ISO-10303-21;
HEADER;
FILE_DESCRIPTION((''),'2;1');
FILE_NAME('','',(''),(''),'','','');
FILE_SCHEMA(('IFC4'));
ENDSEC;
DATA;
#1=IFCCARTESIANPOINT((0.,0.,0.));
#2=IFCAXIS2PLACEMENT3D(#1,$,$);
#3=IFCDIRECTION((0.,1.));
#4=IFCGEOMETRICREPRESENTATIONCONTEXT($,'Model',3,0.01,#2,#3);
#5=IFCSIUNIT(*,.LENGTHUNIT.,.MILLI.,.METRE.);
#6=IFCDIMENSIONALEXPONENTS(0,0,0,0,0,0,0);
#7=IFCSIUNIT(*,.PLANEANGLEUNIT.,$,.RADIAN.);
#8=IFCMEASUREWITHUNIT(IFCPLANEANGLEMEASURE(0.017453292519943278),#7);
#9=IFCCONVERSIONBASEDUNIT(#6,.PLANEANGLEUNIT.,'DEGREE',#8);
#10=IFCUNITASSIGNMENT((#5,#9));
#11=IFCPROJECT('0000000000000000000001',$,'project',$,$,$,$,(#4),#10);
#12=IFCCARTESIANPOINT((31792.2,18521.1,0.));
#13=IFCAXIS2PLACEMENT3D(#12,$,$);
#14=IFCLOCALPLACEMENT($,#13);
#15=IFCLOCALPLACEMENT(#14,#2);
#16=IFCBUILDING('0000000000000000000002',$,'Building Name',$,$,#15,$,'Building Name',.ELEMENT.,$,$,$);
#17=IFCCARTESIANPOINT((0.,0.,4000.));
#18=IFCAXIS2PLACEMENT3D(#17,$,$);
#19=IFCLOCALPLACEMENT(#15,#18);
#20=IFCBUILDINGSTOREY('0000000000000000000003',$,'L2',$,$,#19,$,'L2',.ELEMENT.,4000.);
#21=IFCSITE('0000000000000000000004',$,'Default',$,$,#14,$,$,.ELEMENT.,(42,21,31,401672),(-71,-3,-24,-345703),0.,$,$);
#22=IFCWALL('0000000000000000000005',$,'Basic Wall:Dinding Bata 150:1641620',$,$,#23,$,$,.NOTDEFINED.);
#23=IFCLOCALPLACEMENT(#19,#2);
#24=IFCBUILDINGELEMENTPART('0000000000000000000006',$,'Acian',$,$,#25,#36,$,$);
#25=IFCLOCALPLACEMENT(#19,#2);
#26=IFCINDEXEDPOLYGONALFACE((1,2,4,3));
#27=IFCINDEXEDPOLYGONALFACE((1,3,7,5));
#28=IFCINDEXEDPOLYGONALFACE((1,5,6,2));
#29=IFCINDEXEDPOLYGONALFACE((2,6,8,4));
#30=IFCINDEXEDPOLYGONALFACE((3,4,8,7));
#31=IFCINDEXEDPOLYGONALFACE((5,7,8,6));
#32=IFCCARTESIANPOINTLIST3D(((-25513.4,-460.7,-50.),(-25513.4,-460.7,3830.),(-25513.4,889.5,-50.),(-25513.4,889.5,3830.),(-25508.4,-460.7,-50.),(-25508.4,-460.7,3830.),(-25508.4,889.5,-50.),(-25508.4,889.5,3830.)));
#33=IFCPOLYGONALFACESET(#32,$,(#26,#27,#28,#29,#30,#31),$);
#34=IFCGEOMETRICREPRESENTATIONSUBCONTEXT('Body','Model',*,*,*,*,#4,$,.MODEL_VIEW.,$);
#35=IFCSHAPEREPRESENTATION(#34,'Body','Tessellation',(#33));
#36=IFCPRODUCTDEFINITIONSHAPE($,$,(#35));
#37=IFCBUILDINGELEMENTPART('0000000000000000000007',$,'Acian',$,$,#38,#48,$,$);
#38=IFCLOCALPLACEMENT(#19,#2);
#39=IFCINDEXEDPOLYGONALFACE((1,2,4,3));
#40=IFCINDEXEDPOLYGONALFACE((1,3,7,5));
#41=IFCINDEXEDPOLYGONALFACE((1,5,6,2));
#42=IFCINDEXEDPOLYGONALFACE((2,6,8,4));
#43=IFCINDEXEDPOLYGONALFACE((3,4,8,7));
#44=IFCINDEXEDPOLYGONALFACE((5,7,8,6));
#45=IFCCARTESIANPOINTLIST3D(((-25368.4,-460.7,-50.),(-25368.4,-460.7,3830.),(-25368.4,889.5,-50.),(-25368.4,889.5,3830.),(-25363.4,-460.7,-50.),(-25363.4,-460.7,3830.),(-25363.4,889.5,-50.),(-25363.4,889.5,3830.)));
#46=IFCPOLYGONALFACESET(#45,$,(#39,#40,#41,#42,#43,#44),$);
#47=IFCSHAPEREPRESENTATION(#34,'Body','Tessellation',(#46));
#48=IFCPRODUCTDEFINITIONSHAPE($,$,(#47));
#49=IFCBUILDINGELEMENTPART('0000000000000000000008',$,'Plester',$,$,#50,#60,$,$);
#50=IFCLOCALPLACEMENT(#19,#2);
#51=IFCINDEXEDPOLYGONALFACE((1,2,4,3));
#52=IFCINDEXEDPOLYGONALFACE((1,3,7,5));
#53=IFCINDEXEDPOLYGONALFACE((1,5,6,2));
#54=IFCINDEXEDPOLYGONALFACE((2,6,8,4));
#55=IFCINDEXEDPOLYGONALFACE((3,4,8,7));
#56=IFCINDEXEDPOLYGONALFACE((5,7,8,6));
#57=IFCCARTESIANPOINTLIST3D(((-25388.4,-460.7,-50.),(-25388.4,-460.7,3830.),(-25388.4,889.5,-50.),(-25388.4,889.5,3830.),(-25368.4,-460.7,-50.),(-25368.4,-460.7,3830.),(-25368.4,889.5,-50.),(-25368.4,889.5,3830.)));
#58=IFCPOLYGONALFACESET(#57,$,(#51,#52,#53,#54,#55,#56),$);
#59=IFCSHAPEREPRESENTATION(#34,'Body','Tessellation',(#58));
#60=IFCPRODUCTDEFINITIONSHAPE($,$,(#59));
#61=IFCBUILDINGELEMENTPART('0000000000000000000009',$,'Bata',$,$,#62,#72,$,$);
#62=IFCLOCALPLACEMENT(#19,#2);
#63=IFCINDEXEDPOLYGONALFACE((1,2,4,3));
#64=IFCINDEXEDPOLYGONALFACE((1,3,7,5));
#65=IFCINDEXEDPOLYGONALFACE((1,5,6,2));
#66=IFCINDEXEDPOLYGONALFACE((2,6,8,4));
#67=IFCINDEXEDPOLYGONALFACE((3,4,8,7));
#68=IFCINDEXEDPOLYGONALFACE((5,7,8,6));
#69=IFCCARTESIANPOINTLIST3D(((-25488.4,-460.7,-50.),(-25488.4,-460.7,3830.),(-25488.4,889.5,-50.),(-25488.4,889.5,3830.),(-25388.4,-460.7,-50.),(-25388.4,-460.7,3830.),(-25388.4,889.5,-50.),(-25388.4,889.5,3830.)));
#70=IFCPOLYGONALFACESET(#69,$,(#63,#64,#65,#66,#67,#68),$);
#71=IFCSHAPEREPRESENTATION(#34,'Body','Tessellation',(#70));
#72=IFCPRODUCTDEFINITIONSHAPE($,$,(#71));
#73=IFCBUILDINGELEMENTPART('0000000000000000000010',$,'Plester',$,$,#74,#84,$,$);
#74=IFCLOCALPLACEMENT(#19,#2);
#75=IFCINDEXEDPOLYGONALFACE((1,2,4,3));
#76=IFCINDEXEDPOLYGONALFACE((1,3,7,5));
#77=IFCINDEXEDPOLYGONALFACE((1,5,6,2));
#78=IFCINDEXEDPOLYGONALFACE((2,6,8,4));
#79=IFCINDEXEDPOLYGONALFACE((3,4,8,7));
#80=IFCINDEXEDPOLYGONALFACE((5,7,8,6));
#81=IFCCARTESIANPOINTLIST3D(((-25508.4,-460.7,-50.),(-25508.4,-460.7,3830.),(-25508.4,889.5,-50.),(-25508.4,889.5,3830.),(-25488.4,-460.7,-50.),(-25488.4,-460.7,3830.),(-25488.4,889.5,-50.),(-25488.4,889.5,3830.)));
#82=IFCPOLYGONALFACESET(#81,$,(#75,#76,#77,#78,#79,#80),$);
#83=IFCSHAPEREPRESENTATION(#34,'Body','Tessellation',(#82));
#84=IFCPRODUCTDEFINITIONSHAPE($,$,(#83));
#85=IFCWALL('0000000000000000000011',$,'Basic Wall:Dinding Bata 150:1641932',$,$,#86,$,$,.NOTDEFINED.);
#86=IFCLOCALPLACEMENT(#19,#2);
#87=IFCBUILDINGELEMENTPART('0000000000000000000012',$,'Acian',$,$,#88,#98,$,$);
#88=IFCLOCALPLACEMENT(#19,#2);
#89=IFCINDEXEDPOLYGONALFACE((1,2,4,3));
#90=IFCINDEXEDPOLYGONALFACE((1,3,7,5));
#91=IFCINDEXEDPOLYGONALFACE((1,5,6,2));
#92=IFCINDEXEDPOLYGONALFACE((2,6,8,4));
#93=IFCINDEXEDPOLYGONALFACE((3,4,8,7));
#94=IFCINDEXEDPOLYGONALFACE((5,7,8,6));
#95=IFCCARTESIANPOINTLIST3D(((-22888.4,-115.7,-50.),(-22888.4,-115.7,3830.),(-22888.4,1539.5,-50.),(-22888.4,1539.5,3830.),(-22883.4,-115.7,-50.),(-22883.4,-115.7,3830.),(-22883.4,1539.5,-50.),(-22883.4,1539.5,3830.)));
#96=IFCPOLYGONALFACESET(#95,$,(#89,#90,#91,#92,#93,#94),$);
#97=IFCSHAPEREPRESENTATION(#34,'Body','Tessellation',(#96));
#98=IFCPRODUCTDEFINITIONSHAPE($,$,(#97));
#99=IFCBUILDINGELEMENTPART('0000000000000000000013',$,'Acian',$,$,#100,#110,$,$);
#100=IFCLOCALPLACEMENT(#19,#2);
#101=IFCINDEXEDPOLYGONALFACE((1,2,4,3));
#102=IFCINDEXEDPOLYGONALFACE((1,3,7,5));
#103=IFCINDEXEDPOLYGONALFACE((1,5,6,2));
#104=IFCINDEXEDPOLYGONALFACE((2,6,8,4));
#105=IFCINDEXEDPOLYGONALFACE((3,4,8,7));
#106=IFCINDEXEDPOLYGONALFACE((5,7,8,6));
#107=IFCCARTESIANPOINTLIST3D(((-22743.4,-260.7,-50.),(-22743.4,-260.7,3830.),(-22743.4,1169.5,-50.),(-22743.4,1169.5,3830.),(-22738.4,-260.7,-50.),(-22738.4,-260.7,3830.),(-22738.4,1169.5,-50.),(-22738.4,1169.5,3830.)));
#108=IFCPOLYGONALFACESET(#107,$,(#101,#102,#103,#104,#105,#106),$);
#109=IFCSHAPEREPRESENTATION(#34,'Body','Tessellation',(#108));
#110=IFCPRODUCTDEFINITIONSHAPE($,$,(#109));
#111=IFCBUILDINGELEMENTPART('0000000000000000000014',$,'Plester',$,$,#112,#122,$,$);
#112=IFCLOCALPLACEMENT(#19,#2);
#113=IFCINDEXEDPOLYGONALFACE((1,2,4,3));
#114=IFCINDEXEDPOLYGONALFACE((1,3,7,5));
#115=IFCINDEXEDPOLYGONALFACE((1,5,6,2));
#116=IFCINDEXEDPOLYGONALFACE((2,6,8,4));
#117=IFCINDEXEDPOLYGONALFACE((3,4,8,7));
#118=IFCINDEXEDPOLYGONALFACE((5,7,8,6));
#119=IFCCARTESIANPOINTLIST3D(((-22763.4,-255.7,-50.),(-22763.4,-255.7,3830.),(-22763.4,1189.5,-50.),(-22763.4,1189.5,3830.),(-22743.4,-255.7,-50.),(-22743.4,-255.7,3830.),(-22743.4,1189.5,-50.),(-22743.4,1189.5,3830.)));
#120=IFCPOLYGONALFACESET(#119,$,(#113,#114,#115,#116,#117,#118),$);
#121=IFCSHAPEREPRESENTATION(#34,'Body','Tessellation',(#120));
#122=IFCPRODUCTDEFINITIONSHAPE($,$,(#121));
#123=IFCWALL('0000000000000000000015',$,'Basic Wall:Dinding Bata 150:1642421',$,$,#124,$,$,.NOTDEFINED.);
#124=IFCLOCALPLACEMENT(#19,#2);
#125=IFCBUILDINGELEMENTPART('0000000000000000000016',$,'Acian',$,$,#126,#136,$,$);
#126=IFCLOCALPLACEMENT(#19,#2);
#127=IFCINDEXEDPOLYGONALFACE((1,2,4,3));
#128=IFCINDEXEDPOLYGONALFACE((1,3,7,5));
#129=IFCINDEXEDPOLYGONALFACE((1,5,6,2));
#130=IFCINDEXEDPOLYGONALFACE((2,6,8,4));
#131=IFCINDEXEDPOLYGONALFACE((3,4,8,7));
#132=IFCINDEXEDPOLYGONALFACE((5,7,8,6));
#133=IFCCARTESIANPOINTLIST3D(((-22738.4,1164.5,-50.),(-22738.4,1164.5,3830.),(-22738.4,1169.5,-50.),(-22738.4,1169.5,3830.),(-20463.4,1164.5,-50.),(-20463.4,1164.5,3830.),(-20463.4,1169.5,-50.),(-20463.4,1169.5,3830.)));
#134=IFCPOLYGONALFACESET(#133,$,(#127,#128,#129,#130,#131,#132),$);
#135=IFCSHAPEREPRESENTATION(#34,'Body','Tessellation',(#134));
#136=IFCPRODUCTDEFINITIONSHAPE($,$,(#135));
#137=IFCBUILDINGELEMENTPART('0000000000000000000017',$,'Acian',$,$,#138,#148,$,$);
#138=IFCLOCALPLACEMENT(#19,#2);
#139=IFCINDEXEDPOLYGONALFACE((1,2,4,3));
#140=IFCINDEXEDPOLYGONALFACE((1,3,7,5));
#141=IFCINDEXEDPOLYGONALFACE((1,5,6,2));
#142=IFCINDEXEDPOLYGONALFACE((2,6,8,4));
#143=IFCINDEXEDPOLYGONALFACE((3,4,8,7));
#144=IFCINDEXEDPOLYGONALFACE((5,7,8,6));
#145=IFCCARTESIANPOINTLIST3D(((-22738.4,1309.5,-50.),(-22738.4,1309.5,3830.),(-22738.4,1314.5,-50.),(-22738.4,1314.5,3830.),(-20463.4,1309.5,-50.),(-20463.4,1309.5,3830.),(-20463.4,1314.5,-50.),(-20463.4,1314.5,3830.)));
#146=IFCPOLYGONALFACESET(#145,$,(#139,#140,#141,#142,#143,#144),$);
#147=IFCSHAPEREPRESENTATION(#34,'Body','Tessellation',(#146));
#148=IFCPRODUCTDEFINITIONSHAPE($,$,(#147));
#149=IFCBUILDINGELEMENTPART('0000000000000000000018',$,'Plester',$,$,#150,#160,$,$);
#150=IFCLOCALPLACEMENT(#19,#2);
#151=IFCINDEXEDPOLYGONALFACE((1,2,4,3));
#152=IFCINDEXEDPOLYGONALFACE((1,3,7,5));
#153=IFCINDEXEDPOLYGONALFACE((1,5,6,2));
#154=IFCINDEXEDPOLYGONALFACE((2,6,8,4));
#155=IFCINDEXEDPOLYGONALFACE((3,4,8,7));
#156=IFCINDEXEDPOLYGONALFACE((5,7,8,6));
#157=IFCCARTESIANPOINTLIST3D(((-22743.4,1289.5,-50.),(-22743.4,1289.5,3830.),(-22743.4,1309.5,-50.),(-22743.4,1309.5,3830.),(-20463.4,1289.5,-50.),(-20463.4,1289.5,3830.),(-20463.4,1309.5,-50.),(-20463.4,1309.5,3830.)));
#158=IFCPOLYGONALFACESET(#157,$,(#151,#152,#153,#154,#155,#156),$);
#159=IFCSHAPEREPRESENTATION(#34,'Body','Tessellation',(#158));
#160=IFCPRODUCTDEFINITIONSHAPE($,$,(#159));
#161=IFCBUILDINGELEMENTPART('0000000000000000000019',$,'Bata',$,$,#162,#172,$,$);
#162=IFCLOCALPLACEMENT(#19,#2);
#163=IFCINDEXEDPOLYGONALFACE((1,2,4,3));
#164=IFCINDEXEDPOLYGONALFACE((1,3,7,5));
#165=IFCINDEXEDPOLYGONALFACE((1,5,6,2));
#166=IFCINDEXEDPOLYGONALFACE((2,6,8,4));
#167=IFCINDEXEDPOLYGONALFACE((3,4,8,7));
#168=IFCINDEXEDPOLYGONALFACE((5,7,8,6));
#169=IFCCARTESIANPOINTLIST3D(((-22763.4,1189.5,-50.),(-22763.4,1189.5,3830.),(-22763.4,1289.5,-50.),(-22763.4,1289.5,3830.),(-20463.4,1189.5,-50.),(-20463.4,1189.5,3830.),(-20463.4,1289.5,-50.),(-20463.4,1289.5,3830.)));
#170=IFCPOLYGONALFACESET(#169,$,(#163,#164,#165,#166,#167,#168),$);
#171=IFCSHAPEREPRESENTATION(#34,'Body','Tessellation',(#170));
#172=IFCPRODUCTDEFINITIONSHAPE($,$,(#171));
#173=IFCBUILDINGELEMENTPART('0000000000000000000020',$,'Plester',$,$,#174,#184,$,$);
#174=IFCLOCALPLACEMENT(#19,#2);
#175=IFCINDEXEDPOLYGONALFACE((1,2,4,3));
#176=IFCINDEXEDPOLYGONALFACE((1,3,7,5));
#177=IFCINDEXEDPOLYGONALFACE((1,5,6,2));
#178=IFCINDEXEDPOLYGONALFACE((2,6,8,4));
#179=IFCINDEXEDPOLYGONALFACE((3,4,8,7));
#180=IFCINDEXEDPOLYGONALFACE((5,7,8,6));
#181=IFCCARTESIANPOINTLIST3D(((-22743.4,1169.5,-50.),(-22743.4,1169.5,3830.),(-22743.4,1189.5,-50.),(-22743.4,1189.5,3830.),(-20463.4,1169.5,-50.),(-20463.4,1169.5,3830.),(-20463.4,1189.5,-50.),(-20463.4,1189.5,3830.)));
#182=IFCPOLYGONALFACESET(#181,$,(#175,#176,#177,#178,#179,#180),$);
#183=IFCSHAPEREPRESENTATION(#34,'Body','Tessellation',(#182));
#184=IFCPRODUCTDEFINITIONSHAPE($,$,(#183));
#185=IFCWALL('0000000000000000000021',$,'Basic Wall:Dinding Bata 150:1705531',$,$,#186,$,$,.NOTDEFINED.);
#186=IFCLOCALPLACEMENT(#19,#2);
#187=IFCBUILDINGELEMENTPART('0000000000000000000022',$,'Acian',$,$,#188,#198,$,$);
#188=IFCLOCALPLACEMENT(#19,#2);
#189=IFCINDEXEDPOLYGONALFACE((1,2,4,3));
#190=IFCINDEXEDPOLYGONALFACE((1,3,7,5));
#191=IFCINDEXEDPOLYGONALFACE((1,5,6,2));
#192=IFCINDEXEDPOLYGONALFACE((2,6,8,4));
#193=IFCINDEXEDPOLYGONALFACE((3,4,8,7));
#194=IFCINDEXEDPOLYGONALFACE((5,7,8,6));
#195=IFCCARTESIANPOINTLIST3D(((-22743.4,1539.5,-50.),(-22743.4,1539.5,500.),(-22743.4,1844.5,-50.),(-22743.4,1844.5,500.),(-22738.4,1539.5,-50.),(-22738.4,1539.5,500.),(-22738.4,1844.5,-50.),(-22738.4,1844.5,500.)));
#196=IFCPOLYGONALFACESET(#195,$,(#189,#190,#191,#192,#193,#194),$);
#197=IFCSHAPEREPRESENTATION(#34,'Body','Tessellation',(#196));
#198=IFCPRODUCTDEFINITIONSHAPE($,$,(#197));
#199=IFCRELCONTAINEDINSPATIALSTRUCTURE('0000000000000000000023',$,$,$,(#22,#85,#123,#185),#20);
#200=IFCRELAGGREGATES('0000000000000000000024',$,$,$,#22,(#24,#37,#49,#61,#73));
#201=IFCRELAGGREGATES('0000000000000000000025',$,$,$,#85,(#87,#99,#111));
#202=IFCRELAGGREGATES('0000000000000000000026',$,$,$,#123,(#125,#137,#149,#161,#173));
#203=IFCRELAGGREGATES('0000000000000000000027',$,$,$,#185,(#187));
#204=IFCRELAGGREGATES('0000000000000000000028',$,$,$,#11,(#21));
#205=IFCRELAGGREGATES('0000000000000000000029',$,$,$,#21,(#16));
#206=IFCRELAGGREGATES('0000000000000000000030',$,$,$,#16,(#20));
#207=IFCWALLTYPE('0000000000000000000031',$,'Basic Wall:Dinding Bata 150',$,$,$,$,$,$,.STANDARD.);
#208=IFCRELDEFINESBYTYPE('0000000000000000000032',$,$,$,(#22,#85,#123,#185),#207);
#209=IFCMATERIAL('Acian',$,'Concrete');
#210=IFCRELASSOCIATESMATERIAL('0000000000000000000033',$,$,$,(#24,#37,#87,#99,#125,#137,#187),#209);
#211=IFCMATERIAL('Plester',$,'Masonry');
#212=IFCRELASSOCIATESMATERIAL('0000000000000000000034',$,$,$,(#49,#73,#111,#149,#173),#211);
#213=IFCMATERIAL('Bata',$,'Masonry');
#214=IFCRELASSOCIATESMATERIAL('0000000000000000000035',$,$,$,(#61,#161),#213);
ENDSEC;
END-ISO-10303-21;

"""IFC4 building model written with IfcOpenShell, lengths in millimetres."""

from ifc_helpers import new_model, entity, si_unit, converted_unit, direction, frame, origin, place, context, subcontext, project, spatial, indexed_curve, outline, extrude, material, type_object, element, aggregate, save


model = new_model("IFC4")

# Units and contexts
model_context = context("Model", 3, precision=0.01, world=origin(), true_north=direction((0.0, 1.0)))
body_context = subcontext(model_context, "Body", "Model", "MODEL_VIEW")
ifc_project = project(units=[si_unit("LENGTHUNIT", "METRE", prefix="MILLI"), converted_unit("PLANEANGLEUNIT", "DEGREE", entity("IfcPlaneAngleMeasure", 0.017453292519943278), si_unit("PLANEANGLEUNIT", "RADIAN"), dimensions=[0, 0, 0, 0, 0, 0, 0])], contexts=[model_context])

# Site, building, storey
site_placement = place(None, frame((31792.2, 18521.1, 0.0)))
site = spatial("IfcSite", under=ifc_project, at=site_placement, Name="Default", CompositionType="ELEMENT", RefLatitude=(42, 21, 31, 401672), RefLongitude=(-71, -3, -24, -345703), RefElevation=0.0)
building_placement = place(site_placement, origin())
building = spatial("IfcBuilding", under=site, at=building_placement, Name="Building Name", LongName="Building Name", CompositionType="ELEMENT")
storey_placement = place(building_placement, frame((0.0, 0.0, 4000.0)))
storey = spatial("IfcBuildingStorey", under=building, at=storey_placement, Name="L2", LongName="L2", CompositionType="ELEMENT", Elevation=4000.0)

# Walls, building element parts
wall_type_1 = type_object("IfcWallType", Name="Basic Wall:Dinding Bata 150", PredefinedType="STANDARD")
wall_1_placement = place(storey_placement, frame((-25438.4, 889.5, -50.0), z_axis=(0.0, 0.0, 1.0), x_axis=(0.0, -1.0, 0.0)))
wall_1 = element("IfcWall", 1, at=wall_1_placement, inside=storey, type_object=wall_type_1, Name="Basic Wall:Dinding Bata 150:1641620", PredefinedType="NOTDEFINED")
ifc_material_1 = material(Name="Acian", Category="Concrete")
building_element_part_1_placement = place(wall_1_placement, origin())
building_element_part_1 = element("IfcBuildingElementPart", 2, at=building_element_part_1_placement, material=ifc_material_1, Name="Acian", context=body_context, shape_type="SweptSolid", body=[
    extrude(outline(indexed_curve([(-675.1, -2.5), (675.1, -2.5), (675.1, 2.5), (-675.1, 2.5), (-675.1, -2.5)], self_intersect=False)), frame((675.1, -72.5, 0.0)), (0.0, 0.0, 1.0), 3880.0),
])
building_element_part_2_placement = place(wall_1_placement, origin())
building_element_part_2 = element("IfcBuildingElementPart", 3, at=building_element_part_2_placement, material=ifc_material_1, Name="Acian", context=body_context, shape_type="SweptSolid", body=[
    extrude(outline(indexed_curve([(-675.1, -2.5), (675.1, -2.5), (675.1, 2.5), (-675.1, 2.5), (-675.1, -2.5)], self_intersect=False)), frame((675.1, 72.5, 0.0)), (0.0, 0.0, 1.0), 3880.0),
])
ifc_material_2 = material(Name="Plester", Category="Masonry")
building_element_part_3_placement = place(wall_1_placement, origin())
building_element_part_3 = element("IfcBuildingElementPart", 4, at=building_element_part_3_placement, material=ifc_material_2, Name="Plester", context=body_context, shape_type="SweptSolid", body=[
    extrude(outline(indexed_curve([(-675.1, -10.0), (675.1, -10.0), (675.1, 10.0), (-675.1, 10.0), (-675.1, -10.0)], self_intersect=False)), frame((675.1, 60.0, 0.0)), (0.0, 0.0, 1.0), 3880.0),
])
ifc_material_3 = material(Name="Bata", Category="Masonry")
building_element_part_4_placement = place(wall_1_placement, origin())
building_element_part_4 = element("IfcBuildingElementPart", 5, at=building_element_part_4_placement, material=ifc_material_3, Name="Bata", context=body_context, shape_type="SweptSolid", body=[
    extrude(outline(indexed_curve([(-675.1, -50.0), (675.1, -50.0), (675.1, 50.0), (-675.1, 50.0), (-675.1, -50.0)], self_intersect=False)), frame((675.1, 0.0, 0.0)), (0.0, 0.0, 1.0), 3880.0),
])
building_element_part_5_placement = place(wall_1_placement, origin())
building_element_part_5 = element("IfcBuildingElementPart", 6, at=building_element_part_5_placement, material=ifc_material_2, Name="Plester", context=body_context, shape_type="SweptSolid", body=[
    extrude(outline(indexed_curve([(-675.1, -10.0), (675.1, -10.0), (675.1, 10.0), (-675.1, 10.0), (-675.1, -10.0)], self_intersect=False)), frame((675.1, -60.0, 0.0)), (0.0, 0.0, 1.0), 3880.0),
])
aggregate(wall_1, [building_element_part_1, building_element_part_2, building_element_part_3, building_element_part_4, building_element_part_5])
wall_2_placement = place(storey_placement, frame((-22813.4, 1539.5, -50.0), z_axis=(0.0, 0.0, 1.0), x_axis=(0.0, -1.0, 0.0)))
wall_2 = element("IfcWall", 7, at=wall_2_placement, inside=storey, type_object=wall_type_1, Name="Basic Wall:Dinding Bata 150:1641932", PredefinedType="NOTDEFINED")
building_element_part_6_placement = place(wall_2_placement, origin())
building_element_part_6 = element("IfcBuildingElementPart", 8, at=building_element_part_6_placement, material=ifc_material_1, Name="Acian", context=body_context, shape_type="SweptSolid", body=[
    extrude(outline(indexed_curve([(-827.6, -2.5), (827.6, -2.5), (827.6, 2.5), (-827.6, 2.5), (-827.6, -2.5)], self_intersect=False)), frame((827.6, -72.5, 0.0)), (0.0, 0.0, 1.0), 3880.0),
])
building_element_part_7_placement = place(wall_2_placement, origin())
building_element_part_7 = element("IfcBuildingElementPart", 9, at=building_element_part_7_placement, material=ifc_material_1, Name="Acian", context=body_context, shape_type="SweptSolid", body=[
    extrude(outline(indexed_curve([(-715.1, -2.5), (715.1, -2.5), (715.1, 2.5), (-715.1, 2.5), (-715.1, -2.5)], self_intersect=False)), frame((1085.1, 72.5, 0.0)), (0.0, 0.0, 1.0), 3880.0),
])
building_element_part_8_placement = place(wall_2_placement, origin())
building_element_part_8 = element("IfcBuildingElementPart", 10, at=building_element_part_8_placement, material=ifc_material_2, Name="Plester", context=body_context, shape_type="SweptSolid", body=[
    extrude(outline(indexed_curve([(-722.6, -10.0), (722.6, -10.0), (722.6, 10.0), (-722.6, 10.0), (-722.6, -10.0)], self_intersect=False)), frame((1072.6, 60.0, 0.0)), (0.0, 0.0, 1.0), 3880.0),
])
aggregate(wall_2, [building_element_part_6, building_element_part_7, building_element_part_8])
wall_3_placement = place(storey_placement, frame((-22738.4, 1239.5, -50.0)))
wall_3 = element("IfcWall", 11, at=wall_3_placement, inside=storey, type_object=wall_type_1, Name="Basic Wall:Dinding Bata 150:1642421", PredefinedType="NOTDEFINED")
building_element_part_9_placement = place(wall_3_placement, origin())
building_element_part_9 = element("IfcBuildingElementPart", 12, at=building_element_part_9_placement, material=ifc_material_1, Name="Acian", context=body_context, shape_type="SweptSolid", body=[
    extrude(outline(indexed_curve([(-2.5, -1137.5), (2.5, -1137.5), (2.5, 1137.5), (-2.5, 1137.5), (-2.5, -1137.5)], self_intersect=False)), frame((1137.5, -72.5, 0.0), z_axis=(0.0, 0.0, 1.0), x_axis=(0.0, -1.0, 0.0)), (0.0, 0.0, 1.0), 3880.0),
])
building_element_part_10_placement = place(wall_3_placement, origin())
building_element_part_10 = element("IfcBuildingElementPart", 13, at=building_element_part_10_placement, material=ifc_material_1, Name="Acian", context=body_context, shape_type="SweptSolid", body=[
    extrude(outline(indexed_curve([(-2.5, -1137.5), (2.5, -1137.5), (2.5, 1137.5), (-2.5, 1137.5), (-2.5, -1137.5)], self_intersect=False)), frame((1137.5, 72.5, 0.0), z_axis=(0.0, 0.0, 1.0), x_axis=(0.0, -1.0, 0.0)), (0.0, 0.0, 1.0), 3880.0),
])
building_element_part_11_placement = place(wall_3_placement, origin())
building_element_part_11 = element("IfcBuildingElementPart", 14, at=building_element_part_11_placement, material=ifc_material_2, Name="Plester", context=body_context, shape_type="SweptSolid", body=[
    extrude(outline(indexed_curve([(-10.0, -1140.0), (10.0, -1140.0), (10.0, 1140.0), (-10.0, 1140.0), (-10.0, -1140.0)], self_intersect=False)), frame((1135.0, 60.0, 0.0), z_axis=(0.0, 0.0, 1.0), x_axis=(0.0, -1.0, 0.0)), (0.0, 0.0, 1.0), 3880.0),
])
building_element_part_12_placement = place(wall_3_placement, origin())
building_element_part_12 = element("IfcBuildingElementPart", 15, at=building_element_part_12_placement, material=ifc_material_3, Name="Bata", context=body_context, shape_type="SweptSolid", body=[
    extrude(outline(indexed_curve([(-50.0, -1150.0), (50.0, -1150.0), (50.0, 1150.0), (-50.0, 1150.0), (-50.0, -1150.0)], self_intersect=False)), frame((1125.0, 0.0, 0.0), z_axis=(0.0, 0.0, 1.0), x_axis=(0.0, -1.0, 0.0)), (0.0, 0.0, 1.0), 3880.0),
])
building_element_part_13_placement = place(wall_3_placement, origin())
building_element_part_13 = element("IfcBuildingElementPart", 16, at=building_element_part_13_placement, material=ifc_material_2, Name="Plester", context=body_context, shape_type="SweptSolid", body=[
    extrude(outline(indexed_curve([(-10.0, -1140.0), (10.0, -1140.0), (10.0, 1140.0), (-10.0, 1140.0), (-10.0, -1140.0)], self_intersect=False)), frame((1135.0, -60.0, 0.0), z_axis=(0.0, 0.0, 1.0), x_axis=(0.0, -1.0, 0.0)), (0.0, 0.0, 1.0), 3880.0),
])
aggregate(wall_3, [building_element_part_9, building_element_part_10, building_element_part_11, building_element_part_12, building_element_part_13])
wall_4_placement = place(storey_placement, frame((-22813.4, 1539.5, -50.0), z_axis=(0.0, 0.0, 1.0), x_axis=(0.0, 1.0, 0.0)))
wall_4 = element("IfcWall", 17, at=wall_4_placement, inside=storey, type_object=wall_type_1, Name="Basic Wall:Dinding Bata 150:1705531", PredefinedType="NOTDEFINED")
building_element_part_14_placement = place(wall_4_placement, origin())
building_element_part_14 = element("IfcBuildingElementPart", 18, at=building_element_part_14_placement, material=ifc_material_1, Name="Acian", context=body_context, shape_type="SweptSolid", body=[
    extrude(outline(indexed_curve([(-152.5, -2.5), (152.5, -2.5), (152.5, 2.5), (-152.5, 2.5), (-152.5, -2.5)], self_intersect=False)), frame((152.5, -72.5, 0.0), z_axis=(0.0, 0.0, 1.0), x_axis=(-1.0, 0.0, 0.0)), (0.0, 0.0, 1.0), 550.0),
])
aggregate(wall_4, [building_element_part_14])

save(model, "model.ifc")
